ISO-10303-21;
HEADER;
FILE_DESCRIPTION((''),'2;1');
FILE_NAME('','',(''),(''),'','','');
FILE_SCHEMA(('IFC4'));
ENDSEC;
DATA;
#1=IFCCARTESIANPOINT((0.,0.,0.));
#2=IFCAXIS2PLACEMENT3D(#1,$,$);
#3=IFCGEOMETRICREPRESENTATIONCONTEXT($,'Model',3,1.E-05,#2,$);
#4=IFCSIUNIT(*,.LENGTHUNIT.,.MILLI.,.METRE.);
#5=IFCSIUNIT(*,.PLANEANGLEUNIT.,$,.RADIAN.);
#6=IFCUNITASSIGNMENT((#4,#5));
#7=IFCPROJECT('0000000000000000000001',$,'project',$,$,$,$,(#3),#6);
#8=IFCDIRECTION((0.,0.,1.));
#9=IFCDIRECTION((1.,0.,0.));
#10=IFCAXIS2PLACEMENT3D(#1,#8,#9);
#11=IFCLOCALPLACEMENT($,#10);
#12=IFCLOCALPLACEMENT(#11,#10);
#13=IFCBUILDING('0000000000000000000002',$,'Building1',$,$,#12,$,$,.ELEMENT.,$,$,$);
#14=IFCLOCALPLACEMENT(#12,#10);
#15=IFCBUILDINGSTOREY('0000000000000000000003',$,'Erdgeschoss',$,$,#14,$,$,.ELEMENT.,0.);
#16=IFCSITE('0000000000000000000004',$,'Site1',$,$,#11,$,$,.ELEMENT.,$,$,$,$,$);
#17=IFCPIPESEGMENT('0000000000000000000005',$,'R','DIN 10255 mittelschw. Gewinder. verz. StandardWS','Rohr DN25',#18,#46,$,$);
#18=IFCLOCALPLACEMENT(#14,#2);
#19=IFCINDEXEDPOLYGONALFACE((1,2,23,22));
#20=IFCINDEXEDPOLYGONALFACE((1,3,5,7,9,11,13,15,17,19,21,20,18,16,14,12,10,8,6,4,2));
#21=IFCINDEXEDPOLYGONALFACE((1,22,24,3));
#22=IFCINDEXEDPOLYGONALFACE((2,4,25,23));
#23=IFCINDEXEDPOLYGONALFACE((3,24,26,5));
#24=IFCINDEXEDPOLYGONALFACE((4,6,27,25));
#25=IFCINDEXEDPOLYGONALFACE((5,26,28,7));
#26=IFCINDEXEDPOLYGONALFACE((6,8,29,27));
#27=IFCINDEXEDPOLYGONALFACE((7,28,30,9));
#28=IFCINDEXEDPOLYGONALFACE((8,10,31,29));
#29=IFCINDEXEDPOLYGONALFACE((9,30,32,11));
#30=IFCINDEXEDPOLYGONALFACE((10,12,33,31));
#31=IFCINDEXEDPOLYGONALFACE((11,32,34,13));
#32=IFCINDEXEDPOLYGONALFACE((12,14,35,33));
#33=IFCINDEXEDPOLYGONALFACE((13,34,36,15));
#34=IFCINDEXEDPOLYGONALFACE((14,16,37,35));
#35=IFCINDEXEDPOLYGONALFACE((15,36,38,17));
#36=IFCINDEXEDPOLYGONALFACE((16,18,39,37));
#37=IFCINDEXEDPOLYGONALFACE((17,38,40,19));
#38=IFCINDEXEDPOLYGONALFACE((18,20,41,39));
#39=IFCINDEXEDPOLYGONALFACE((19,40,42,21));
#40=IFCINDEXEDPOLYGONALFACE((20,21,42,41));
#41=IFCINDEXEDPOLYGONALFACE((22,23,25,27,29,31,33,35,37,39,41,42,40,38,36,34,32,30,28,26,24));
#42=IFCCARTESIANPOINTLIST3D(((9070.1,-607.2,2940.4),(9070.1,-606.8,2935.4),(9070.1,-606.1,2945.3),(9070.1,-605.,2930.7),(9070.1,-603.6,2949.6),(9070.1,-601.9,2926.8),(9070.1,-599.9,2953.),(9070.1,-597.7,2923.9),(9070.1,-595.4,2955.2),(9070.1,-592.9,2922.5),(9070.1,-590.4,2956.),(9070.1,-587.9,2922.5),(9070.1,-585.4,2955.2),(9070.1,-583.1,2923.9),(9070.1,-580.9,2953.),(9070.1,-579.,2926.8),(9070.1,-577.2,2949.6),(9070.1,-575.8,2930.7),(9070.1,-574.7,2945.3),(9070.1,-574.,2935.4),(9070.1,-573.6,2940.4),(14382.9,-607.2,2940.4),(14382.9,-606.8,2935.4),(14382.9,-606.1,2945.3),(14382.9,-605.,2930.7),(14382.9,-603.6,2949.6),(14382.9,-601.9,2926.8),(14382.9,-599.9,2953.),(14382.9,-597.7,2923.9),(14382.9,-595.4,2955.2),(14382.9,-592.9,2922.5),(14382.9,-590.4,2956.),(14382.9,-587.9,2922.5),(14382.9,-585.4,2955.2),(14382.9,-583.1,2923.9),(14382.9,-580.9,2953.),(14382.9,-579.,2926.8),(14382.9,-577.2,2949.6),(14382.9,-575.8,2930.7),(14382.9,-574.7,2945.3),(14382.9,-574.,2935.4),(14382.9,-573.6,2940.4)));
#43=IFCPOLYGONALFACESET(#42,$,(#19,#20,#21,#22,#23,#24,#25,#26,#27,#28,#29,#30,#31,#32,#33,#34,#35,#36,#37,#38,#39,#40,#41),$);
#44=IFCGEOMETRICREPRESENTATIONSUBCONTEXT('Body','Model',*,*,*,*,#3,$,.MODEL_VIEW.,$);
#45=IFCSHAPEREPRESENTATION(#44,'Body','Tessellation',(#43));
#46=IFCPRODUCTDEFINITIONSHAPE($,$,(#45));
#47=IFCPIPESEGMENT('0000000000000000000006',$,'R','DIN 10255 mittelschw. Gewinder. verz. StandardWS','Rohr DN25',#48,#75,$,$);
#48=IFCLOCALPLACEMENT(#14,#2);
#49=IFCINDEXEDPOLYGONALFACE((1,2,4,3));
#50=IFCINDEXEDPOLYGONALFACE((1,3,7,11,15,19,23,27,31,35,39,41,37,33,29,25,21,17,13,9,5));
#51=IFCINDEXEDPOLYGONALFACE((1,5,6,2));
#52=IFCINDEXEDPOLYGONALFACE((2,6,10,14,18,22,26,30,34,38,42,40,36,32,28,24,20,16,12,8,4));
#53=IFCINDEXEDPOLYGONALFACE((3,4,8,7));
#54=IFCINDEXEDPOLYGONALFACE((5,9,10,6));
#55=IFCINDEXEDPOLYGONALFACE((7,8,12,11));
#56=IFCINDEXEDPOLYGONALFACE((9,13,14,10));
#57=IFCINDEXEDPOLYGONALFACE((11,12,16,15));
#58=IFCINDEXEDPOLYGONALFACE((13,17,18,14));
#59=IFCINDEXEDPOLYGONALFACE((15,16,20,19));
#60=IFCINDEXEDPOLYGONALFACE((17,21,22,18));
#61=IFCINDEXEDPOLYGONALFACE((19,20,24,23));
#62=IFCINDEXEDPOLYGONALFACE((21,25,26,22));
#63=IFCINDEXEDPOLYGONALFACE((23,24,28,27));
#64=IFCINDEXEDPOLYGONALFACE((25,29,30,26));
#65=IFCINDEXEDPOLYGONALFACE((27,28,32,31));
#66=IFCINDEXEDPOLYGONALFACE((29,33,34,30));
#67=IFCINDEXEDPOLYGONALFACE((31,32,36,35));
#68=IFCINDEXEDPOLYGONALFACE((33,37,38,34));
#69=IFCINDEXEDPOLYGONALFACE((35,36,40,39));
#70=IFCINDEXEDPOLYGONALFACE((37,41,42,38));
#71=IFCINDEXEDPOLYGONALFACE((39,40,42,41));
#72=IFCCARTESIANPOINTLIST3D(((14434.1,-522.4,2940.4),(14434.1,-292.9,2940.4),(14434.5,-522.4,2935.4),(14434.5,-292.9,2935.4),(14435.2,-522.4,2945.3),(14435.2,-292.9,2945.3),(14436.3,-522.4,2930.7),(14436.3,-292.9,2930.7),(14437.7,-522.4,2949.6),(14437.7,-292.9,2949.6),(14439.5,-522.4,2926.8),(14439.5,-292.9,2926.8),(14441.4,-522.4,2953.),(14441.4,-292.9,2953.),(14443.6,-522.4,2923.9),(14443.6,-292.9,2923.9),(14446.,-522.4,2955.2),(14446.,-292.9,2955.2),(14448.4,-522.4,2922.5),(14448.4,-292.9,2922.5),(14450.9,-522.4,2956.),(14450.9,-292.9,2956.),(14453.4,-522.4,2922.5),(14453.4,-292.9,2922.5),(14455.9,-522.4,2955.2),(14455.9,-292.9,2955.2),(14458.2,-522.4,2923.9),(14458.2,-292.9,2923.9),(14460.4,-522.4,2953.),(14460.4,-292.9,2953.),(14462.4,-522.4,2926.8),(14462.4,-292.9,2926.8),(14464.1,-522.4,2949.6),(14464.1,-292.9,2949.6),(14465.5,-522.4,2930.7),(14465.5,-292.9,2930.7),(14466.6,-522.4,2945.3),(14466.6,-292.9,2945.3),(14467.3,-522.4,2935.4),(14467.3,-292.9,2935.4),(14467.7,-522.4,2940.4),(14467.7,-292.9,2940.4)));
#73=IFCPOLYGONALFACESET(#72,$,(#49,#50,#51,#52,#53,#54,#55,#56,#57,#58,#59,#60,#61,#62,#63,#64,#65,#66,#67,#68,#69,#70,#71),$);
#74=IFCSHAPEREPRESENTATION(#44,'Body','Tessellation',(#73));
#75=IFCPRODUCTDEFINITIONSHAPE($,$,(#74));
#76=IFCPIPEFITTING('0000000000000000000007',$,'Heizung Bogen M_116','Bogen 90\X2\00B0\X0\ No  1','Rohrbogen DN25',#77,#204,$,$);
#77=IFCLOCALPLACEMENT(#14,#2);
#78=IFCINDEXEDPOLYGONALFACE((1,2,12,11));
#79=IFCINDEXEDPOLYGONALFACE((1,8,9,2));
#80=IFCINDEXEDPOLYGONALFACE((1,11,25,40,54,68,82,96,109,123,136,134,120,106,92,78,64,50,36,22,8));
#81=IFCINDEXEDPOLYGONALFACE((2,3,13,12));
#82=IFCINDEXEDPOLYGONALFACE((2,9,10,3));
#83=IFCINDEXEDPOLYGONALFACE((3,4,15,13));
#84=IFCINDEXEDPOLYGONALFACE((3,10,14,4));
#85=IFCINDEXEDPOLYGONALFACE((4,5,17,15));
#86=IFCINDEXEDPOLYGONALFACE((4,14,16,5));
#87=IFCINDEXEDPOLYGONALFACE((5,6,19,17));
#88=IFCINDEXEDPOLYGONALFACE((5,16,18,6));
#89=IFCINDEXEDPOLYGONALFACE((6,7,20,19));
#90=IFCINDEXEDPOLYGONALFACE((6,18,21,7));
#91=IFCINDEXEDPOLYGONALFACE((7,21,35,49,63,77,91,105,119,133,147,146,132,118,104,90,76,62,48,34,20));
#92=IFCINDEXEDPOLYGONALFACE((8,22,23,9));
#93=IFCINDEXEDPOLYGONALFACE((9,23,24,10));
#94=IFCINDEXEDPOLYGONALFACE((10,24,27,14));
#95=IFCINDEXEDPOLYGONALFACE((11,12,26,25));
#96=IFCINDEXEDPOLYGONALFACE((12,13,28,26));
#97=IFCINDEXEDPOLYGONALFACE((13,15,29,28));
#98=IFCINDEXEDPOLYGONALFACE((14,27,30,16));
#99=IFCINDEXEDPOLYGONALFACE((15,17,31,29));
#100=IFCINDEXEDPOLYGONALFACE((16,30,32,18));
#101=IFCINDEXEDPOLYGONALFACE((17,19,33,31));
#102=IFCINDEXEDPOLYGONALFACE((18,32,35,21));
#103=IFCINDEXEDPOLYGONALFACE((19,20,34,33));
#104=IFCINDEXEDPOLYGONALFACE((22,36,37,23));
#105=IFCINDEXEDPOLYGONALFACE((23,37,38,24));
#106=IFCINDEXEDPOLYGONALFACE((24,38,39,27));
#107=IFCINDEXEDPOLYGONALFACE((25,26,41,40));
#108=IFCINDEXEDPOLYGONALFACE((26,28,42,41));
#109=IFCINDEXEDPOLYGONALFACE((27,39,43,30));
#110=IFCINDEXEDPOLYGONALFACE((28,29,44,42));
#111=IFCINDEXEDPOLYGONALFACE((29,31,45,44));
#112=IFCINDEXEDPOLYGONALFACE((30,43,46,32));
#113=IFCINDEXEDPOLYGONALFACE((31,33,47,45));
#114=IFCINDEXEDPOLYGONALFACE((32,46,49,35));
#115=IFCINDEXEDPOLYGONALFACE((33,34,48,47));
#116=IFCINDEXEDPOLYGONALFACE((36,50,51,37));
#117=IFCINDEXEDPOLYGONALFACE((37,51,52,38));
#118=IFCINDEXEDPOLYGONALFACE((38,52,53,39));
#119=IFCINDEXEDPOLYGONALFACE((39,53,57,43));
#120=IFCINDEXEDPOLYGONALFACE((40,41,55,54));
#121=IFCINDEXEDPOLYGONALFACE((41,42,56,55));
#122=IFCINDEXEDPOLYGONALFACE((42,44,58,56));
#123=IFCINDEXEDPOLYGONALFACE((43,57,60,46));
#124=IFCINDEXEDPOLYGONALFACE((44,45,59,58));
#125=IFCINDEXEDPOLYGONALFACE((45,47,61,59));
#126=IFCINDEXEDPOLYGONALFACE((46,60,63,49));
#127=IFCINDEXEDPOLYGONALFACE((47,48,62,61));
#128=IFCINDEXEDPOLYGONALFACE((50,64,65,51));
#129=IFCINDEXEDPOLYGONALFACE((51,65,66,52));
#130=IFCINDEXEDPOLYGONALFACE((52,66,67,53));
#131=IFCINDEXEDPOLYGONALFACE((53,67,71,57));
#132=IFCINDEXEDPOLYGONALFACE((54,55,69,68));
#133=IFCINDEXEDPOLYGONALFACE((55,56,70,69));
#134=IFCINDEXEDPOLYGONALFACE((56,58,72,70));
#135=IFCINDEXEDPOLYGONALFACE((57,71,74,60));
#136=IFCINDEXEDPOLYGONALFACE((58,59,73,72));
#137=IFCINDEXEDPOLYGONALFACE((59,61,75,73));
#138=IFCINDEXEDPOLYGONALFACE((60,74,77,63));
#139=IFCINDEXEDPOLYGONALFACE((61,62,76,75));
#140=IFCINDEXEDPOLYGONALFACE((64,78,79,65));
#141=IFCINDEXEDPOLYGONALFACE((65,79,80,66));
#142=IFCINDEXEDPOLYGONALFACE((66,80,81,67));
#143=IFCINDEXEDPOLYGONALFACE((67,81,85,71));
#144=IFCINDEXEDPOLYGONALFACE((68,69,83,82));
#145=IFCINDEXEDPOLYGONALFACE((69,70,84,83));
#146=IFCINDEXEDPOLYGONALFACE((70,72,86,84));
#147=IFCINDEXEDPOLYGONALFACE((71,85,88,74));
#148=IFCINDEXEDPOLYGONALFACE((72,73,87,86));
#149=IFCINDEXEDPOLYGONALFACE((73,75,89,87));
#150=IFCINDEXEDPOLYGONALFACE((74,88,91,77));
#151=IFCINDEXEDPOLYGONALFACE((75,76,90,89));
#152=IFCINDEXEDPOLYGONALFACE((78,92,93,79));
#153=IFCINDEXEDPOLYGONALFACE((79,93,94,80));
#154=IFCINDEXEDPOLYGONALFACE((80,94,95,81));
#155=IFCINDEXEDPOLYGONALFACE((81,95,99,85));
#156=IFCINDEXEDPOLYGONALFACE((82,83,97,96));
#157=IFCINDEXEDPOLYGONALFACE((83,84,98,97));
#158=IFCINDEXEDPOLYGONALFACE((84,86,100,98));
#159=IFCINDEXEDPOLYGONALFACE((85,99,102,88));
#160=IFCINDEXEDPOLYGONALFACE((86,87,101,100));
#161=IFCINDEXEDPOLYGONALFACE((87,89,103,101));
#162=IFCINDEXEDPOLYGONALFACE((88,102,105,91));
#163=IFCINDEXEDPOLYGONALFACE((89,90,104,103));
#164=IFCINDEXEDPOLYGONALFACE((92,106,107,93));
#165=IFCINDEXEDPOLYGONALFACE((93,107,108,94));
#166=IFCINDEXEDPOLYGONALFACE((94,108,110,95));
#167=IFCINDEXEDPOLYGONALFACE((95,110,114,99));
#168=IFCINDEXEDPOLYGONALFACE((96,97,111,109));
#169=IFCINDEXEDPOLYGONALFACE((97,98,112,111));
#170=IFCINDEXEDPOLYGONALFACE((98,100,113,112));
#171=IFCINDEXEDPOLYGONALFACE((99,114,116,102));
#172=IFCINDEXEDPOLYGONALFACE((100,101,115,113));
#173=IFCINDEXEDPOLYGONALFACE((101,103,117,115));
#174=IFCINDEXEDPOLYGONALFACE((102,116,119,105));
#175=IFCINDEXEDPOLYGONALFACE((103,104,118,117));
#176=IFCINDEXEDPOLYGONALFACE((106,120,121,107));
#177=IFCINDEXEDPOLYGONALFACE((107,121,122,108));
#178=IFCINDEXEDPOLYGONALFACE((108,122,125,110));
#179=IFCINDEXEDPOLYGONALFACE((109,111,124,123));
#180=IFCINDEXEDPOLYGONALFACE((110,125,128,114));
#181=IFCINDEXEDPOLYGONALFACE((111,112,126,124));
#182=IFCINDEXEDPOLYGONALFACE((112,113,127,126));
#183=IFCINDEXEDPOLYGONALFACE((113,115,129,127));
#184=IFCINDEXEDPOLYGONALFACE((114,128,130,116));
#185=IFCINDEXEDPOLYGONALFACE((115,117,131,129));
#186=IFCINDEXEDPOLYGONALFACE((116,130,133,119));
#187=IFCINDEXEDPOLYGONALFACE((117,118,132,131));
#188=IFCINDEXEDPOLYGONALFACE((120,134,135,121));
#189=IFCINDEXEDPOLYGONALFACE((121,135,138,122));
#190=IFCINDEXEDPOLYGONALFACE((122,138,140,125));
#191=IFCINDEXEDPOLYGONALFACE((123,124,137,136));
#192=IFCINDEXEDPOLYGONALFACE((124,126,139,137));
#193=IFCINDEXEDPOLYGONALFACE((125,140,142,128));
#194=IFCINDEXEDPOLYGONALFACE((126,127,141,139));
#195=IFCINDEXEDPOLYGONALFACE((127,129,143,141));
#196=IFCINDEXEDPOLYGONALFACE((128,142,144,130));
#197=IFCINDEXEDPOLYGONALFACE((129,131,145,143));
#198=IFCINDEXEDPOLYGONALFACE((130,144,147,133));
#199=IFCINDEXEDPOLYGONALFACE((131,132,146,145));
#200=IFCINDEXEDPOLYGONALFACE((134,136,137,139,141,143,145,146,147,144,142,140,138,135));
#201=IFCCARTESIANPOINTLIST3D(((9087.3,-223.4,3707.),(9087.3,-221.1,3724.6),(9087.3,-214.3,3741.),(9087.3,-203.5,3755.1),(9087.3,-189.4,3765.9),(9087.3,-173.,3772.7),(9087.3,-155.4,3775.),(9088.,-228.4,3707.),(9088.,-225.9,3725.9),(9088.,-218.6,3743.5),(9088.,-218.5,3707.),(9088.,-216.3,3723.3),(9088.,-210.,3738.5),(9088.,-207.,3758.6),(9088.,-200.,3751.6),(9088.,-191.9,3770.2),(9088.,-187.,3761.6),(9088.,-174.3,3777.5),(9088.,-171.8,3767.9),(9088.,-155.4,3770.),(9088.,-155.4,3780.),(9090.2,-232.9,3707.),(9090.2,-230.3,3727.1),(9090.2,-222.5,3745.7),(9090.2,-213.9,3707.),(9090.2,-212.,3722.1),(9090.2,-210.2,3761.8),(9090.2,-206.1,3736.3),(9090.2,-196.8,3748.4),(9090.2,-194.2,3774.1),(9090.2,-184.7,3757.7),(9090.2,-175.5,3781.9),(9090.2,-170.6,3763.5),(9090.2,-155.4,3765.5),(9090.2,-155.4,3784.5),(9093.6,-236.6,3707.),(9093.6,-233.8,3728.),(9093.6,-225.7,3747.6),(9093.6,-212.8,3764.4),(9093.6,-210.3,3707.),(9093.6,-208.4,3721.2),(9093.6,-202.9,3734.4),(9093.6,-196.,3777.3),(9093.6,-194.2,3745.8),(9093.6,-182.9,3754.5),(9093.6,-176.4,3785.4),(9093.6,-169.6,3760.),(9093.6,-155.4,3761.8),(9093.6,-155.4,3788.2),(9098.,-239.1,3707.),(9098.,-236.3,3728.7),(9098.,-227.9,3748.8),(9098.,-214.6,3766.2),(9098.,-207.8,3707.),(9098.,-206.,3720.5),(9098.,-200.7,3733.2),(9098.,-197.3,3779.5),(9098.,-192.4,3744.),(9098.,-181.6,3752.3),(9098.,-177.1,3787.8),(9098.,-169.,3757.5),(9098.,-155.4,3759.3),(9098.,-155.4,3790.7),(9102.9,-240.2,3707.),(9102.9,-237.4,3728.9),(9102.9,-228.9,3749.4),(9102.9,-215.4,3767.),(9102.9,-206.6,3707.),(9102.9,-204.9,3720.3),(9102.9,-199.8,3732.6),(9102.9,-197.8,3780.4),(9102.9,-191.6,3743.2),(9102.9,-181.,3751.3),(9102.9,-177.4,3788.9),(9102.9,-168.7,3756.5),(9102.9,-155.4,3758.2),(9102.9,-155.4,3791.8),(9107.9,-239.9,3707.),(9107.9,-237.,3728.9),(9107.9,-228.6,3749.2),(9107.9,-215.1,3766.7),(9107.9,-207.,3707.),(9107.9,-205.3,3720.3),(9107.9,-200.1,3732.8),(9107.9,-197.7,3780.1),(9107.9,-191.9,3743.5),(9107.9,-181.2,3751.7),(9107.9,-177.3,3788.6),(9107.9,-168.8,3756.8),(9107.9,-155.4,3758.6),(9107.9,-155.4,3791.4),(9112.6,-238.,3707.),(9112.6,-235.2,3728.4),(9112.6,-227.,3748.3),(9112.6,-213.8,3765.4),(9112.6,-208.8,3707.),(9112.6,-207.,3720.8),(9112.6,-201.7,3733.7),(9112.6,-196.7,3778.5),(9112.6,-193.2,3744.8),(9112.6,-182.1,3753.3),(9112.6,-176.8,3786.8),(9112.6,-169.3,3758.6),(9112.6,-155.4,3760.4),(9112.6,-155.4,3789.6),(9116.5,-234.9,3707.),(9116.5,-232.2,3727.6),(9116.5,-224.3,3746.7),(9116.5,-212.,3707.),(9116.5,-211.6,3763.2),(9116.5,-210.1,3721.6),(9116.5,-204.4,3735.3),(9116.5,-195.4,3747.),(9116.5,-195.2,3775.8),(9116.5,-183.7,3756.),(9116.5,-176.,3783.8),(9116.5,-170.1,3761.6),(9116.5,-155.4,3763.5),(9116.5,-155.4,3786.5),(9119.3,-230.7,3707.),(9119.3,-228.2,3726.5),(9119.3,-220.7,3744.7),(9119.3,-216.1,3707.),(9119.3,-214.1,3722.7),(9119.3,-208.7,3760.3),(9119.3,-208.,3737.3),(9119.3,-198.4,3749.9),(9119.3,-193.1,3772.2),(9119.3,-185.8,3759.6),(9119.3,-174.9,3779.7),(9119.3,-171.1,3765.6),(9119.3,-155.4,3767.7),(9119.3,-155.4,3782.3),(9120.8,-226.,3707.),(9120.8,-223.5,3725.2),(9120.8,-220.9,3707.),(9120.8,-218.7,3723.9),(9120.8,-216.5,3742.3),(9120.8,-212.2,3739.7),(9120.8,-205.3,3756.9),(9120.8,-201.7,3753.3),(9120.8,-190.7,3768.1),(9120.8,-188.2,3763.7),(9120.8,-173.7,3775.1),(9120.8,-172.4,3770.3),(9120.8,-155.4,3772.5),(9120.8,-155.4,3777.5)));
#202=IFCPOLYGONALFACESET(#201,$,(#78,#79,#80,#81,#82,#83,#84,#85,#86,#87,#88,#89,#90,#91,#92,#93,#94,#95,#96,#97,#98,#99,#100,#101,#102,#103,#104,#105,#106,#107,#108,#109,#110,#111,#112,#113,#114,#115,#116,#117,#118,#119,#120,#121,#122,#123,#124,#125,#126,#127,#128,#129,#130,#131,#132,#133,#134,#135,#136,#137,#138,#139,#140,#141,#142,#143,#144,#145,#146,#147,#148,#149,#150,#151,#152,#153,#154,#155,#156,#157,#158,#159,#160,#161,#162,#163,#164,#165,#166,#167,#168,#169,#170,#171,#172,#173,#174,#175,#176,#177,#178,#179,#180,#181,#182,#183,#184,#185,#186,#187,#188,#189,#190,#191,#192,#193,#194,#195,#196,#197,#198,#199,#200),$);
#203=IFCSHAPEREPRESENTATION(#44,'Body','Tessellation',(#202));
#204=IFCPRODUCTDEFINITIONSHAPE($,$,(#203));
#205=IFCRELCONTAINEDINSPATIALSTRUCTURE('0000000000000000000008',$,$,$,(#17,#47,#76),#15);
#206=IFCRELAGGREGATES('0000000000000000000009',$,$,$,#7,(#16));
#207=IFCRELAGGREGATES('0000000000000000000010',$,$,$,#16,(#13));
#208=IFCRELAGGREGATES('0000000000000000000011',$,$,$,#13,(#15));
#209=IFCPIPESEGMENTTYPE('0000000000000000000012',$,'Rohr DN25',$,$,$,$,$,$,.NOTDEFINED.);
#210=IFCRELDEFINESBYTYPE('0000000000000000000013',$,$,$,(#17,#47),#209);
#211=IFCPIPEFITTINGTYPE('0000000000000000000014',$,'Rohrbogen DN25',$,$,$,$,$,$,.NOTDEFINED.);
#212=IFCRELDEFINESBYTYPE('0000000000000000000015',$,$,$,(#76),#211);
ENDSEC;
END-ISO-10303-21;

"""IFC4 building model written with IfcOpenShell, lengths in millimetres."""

from ifc_helpers import new_model, entity, si_unit, frame, origin, origin_with_axes, origin_2d_with_axis, place, context, subcontext, project, spatial, circle, extrude, shape, source, transform, mapped, type_object, element, save


model = new_model("IFC4")

# Units and contexts
model_context = context("Model", 3, precision=1e-05, world=origin())
body_context = subcontext(model_context, "Body", "Model", "MODEL_VIEW")
ifc_project = project(units=[si_unit("LENGTHUNIT", "METRE", prefix="MILLI"), si_unit("PLANEANGLEUNIT", "RADIAN")], contexts=[model_context])

# Site, building, storey
site_placement = place(None, origin_with_axes())
site = spatial("IfcSite", under=ifc_project, at=site_placement, Name="Site1", CompositionType="ELEMENT")
building_placement = place(site_placement, origin_with_axes())
building = spatial("IfcBuilding", under=site, at=building_placement, Name="Building1", CompositionType="ELEMENT")
storey_placement = place(building_placement, origin_with_axes())
storey = spatial("IfcBuildingStorey", under=building, at=storey_placement, Name="Erdgeschoss", CompositionType="ELEMENT", Elevation=0.0)

# Pipe segments
pipe_segment_type_1 = type_object("IfcPipeSegmentType", Name="Rohr DN25", PredefinedType="NOTDEFINED")
pipe_segment_1_placement = place(storey_placement, frame((11726.5, -590.3, 2939.1), z_axis=(0.0, 0.0, 1.0), x_axis=(1.0, 0.0, 0.0)))
element("IfcPipeSegment", 1, at=pipe_segment_1_placement, inside=storey, type_object=pipe_segment_type_1, Name="R", Description="DIN 10255 mittelschw. Gewinder. verz. StandardWS", ObjectType="Rohr DN25", context=body_context, shape_type="SolidModel", body=[
    extrude(circle(Radius=16.9, at=origin_2d_with_axis()), frame((-2656.4, -0.2, 0.0), z_axis=(1.0, 0.0, 0.0), x_axis=(0.0, 0.0, 1.0)), (0.0, 0.0, 1.0), 5312.8),
])
pipe_segment_2_placement = place(storey_placement, frame((14450.8, -407.6, 2939.1), z_axis=(0.0, 0.0, 1.0), x_axis=(1.0, 0.0, 0.0)))
element("IfcPipeSegment", 2, at=pipe_segment_2_placement, inside=storey, type_object=pipe_segment_type_1, Name="R", Description="DIN 10255 mittelschw. Gewinder. verz. StandardWS", ObjectType="Rohr DN25", context=body_context, shape_type="SolidModel", body=[
    extrude(circle(Radius=16.9, at=origin_2d_with_axis()), frame((0.2, -114.8, 0.0), z_axis=(-0.000001, 1.0, 0.0), x_axis=(0.0, 0.0, 1.0)), (0.0, 0.0, 1.0), 229.5),
])

# Pipe fitting
pipe_fitting_type = type_object("IfcPipeFittingType", Name="Rohrbogen DN25", PredefinedType="NOTDEFINED")
shared_shape_1 = source(origin_with_axes(), body_context, "Body", "SolidModel", [
    entity("IfcRevolvedAreaSolid", entity("IfcCircleProfileDef", "AREA", None, entity("IfcAxis2Placement2D", entity("IfcCartesianPoint", [0.0, 0.0]), entity("IfcDirection", [1.0, 0.0])), 16.9), entity("IfcAxis2Placement3D", entity("IfcCartesianPoint", [-42.4, 0.0, 25.6]), entity("IfcDirection", [1.0, 0.0, 0.0]), entity("IfcDirection", [0.0, -1.0, 0.0])), entity("IfcAxis1Placement", entity("IfcCartesianPoint", [0.0, 68.0, 0.0]), entity("IfcDirection", [-1.0, 0.0, 0.0])), 1.570796),
])
pipe_fitting_1_placement = place(storey_placement, frame((9104.1, -197.9, 3749.4), z_axis=(0.0, 0.0, 1.0), x_axis=(1.0, 0.0, 0.0)))
element("IfcPipeFitting", 3, at=pipe_fitting_1_placement, inside=storey, type_object=pipe_fitting_type, Name="Heizung Bogen M_116", Description="Bogen 90° No  1", ObjectType="Rohrbogen DN25", shapes=[
    shape(body_context, "Body", "MappedRepresentation", [mapped(shared_shape_1, transform((0.0, 0.0, 0.0), x_axis=(0.0, -1.0, 0.0), y_axis=(1.0, 0.0, 0.0), z_axis=(0.0, 0.0, 1.0), scale=1.0))]),
    shape(body_context, "Body", "MappedRepresentation", [mapped(shared_shape_1, transform((0.0, 0.0, 0.0), x_axis=(0.0, -1.0, 0.0), y_axis=(1.0, 0.0, 0.0), z_axis=(0.0, 0.0, 1.0), scale=1.0))]),
])

save(model, "model.ifc")
